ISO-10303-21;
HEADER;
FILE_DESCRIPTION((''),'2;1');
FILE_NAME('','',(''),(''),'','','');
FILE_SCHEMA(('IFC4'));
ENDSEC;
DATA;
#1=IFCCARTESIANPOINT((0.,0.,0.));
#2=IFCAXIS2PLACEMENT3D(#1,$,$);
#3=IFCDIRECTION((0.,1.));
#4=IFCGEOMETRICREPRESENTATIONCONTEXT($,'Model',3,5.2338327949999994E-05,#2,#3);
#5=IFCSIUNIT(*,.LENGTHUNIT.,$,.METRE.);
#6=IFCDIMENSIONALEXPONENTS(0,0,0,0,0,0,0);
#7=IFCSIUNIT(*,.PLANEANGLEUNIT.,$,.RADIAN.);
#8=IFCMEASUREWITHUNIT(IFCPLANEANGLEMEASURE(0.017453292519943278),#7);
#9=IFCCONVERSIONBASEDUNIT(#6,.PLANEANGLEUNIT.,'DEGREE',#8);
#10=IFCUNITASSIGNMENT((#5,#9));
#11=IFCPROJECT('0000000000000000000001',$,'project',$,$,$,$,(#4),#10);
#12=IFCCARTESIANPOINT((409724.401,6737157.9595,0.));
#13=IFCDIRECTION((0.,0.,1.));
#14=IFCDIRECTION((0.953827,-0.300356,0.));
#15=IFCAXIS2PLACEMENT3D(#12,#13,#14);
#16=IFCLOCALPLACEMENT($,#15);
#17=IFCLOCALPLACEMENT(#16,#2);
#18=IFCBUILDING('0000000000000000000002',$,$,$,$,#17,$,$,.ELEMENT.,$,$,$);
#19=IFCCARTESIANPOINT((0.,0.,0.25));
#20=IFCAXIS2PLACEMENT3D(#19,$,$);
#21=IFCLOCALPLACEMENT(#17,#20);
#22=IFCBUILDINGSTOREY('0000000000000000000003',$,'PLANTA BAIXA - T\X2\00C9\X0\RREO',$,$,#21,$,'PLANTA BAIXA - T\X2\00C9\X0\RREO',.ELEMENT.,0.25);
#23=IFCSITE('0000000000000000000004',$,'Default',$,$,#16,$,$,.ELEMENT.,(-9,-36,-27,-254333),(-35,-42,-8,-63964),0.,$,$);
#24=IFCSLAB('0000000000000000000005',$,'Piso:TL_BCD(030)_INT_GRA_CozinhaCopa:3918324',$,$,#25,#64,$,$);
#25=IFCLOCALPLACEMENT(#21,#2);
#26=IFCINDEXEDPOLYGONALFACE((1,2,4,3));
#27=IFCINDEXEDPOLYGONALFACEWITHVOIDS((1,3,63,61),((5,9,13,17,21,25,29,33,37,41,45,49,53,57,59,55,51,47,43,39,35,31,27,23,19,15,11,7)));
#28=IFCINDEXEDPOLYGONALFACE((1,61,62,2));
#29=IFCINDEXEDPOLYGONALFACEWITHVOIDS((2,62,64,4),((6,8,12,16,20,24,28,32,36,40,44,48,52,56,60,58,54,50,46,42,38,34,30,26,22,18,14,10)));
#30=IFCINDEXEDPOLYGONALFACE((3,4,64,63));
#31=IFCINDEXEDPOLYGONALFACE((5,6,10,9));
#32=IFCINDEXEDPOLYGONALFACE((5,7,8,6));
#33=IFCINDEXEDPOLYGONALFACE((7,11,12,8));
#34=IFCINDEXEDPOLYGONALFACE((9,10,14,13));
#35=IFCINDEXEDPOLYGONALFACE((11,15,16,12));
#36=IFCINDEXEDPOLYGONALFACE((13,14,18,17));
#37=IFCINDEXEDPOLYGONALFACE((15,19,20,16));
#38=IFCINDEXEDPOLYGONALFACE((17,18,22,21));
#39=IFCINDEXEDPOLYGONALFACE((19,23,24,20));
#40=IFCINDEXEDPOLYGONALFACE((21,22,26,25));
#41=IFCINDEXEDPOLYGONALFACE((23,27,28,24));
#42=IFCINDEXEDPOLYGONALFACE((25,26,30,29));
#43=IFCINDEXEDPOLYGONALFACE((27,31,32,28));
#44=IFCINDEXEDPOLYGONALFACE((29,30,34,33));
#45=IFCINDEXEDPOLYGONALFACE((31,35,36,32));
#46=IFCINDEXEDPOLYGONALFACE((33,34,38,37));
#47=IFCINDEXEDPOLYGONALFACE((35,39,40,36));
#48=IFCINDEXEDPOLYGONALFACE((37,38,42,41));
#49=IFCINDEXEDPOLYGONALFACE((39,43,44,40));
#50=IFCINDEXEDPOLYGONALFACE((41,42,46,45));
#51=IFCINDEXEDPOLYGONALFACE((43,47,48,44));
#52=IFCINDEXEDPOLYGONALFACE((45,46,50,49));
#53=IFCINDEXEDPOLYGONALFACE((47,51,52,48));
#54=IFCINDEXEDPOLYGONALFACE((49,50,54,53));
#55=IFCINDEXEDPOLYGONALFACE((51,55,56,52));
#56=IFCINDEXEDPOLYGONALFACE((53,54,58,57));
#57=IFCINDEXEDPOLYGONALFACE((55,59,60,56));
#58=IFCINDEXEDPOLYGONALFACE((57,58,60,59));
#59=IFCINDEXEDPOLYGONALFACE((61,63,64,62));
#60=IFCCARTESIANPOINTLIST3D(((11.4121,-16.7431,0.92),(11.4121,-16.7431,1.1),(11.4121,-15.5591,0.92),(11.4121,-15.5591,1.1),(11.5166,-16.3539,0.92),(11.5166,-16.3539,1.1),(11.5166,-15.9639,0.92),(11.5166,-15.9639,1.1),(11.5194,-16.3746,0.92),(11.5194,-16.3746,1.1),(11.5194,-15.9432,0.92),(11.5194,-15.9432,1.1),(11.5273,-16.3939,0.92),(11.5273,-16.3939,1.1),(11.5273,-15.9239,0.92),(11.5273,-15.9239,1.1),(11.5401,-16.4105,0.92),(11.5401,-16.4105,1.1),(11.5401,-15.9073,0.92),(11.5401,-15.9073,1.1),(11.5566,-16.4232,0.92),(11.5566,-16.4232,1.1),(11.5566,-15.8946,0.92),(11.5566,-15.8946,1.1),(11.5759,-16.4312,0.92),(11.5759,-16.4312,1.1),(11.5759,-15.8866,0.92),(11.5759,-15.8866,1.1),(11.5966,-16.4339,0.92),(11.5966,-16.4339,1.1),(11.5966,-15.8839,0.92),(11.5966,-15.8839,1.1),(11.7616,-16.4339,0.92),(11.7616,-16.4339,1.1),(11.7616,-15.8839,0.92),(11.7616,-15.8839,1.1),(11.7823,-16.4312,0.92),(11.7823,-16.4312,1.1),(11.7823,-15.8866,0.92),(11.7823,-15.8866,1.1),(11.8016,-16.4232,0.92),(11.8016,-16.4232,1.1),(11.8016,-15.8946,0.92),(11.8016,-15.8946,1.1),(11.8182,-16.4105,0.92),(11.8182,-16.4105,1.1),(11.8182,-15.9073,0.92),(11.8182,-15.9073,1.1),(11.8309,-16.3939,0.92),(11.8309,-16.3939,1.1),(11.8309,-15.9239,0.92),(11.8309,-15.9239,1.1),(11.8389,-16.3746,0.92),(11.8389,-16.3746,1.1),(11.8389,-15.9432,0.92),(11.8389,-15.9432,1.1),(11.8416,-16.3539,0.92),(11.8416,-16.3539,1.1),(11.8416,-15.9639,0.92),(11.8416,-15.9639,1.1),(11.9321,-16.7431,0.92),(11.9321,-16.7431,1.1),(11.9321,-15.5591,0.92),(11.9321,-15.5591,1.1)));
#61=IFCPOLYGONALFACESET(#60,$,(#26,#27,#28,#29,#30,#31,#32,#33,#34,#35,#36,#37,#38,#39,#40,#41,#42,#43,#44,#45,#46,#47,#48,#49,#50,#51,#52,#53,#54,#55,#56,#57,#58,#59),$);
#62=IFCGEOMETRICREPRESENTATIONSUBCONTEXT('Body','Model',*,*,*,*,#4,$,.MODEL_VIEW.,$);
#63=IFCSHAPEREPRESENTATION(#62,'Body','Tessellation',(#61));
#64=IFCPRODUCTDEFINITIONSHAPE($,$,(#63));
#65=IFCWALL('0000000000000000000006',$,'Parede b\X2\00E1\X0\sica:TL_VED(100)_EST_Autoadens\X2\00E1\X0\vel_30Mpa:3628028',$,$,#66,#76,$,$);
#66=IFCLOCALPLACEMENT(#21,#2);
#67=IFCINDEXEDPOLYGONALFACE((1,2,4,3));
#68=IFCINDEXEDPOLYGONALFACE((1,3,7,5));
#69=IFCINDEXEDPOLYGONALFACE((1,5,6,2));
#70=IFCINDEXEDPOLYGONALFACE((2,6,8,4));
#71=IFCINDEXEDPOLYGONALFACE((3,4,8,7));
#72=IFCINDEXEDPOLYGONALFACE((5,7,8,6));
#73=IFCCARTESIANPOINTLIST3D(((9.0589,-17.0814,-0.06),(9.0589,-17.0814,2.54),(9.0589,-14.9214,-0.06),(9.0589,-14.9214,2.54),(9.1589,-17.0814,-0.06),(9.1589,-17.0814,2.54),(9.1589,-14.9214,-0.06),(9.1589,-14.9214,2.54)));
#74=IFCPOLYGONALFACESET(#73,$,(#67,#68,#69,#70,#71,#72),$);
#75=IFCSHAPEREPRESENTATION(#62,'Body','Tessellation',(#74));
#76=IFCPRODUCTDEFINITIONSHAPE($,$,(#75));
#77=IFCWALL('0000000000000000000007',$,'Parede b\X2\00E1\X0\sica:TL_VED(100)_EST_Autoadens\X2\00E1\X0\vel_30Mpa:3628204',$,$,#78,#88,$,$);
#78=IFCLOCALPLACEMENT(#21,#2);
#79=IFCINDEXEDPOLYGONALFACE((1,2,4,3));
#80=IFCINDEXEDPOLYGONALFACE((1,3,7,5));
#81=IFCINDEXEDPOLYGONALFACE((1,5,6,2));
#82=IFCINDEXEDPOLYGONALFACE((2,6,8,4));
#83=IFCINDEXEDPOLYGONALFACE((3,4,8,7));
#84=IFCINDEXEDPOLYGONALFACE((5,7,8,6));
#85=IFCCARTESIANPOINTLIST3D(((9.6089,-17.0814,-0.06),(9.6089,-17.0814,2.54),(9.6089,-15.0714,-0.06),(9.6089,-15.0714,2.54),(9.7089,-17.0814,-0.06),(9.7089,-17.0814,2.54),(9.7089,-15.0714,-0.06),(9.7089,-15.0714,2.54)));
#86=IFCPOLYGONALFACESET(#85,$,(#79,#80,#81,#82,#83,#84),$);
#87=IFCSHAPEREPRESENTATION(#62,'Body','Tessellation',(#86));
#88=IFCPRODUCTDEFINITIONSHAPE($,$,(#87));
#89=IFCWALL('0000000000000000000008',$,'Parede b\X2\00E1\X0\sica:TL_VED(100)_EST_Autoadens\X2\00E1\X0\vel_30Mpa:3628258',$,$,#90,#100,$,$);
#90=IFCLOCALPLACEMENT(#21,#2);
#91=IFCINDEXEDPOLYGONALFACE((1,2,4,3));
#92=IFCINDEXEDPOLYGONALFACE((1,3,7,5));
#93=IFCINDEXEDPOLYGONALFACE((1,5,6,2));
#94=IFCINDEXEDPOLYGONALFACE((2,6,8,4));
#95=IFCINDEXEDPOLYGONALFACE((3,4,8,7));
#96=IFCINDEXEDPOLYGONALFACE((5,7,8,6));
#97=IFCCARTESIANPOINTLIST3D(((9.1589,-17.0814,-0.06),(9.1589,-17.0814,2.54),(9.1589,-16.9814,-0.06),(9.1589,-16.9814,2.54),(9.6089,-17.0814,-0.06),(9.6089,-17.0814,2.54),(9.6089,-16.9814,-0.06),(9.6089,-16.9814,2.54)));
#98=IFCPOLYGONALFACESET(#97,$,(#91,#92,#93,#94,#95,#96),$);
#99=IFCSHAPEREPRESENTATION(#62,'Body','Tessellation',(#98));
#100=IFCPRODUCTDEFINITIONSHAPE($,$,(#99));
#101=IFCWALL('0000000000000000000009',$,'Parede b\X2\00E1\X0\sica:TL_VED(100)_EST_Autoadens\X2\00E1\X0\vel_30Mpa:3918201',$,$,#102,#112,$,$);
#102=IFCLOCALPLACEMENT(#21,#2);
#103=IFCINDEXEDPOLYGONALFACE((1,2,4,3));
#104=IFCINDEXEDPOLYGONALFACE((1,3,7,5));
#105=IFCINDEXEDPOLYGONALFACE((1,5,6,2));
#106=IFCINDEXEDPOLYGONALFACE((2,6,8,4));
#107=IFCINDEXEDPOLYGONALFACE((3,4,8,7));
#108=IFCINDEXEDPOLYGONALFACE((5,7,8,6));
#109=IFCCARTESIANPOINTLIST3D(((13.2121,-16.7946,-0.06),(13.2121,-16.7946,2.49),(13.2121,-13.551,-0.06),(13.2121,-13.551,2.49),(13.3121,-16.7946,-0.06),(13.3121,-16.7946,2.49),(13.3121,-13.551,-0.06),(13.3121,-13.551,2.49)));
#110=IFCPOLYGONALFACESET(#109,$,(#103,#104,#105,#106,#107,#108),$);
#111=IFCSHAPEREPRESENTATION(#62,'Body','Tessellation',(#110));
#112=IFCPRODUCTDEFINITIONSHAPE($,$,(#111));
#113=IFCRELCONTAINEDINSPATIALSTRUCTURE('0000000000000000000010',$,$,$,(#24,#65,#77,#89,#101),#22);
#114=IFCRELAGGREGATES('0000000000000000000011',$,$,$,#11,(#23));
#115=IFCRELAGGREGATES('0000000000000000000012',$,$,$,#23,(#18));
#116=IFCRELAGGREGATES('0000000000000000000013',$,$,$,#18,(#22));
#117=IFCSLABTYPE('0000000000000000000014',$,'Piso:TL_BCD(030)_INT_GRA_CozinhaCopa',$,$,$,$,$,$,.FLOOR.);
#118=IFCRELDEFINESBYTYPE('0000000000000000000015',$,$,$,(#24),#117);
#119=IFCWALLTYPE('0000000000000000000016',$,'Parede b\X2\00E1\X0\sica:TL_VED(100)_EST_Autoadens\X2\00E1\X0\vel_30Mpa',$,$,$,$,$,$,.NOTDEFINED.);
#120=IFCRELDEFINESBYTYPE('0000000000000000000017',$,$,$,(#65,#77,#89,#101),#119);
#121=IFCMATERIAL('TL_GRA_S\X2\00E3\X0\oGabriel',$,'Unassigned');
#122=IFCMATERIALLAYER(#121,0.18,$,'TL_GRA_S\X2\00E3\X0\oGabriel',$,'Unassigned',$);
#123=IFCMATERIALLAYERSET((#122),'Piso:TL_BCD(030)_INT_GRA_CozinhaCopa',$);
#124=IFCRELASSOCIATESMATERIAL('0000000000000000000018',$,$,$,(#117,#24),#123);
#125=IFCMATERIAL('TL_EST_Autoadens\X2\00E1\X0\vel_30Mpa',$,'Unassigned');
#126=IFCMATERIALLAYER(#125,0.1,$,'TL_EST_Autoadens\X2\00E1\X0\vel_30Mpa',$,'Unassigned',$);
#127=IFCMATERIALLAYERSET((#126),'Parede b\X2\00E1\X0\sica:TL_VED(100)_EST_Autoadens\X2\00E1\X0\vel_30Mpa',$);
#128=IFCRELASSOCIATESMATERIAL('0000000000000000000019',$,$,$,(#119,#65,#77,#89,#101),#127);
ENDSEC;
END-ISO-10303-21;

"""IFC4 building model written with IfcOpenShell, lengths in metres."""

from ifc_helpers import new_model, entity, si_unit, converted_unit, direction, frame, frame_2d, origin, place, context, subcontext, project, spatial, polyline, circle_curve, parameter, trimmed, segment, composite_curve, rectangle, outline, extrude, material, layer, layer_set, layer_usage, type_object, element, save


model = new_model("IFC4")

# Units and contexts
model_context = context("Model", 3, precision=5.2338327949999994e-05, world=origin(), true_north=direction((0.0, 1.0)))
body_context = subcontext(model_context, "Body", "Model", "MODEL_VIEW")
ifc_project = project(units=[si_unit("LENGTHUNIT", "METRE"), converted_unit("PLANEANGLEUNIT", "DEGREE", entity("IfcPlaneAngleMeasure", 0.017453292519943278), si_unit("PLANEANGLEUNIT", "RADIAN"), dimensions=[0, 0, 0, 0, 0, 0, 0])], contexts=[model_context])

# Site, building, storey
site_placement = place(None, frame((409724.401, 6737157.9595, 0.0), z_axis=(0.0, 0.0, 1.0), x_axis=(0.953827, -0.300356, 0.0)))
site = spatial("IfcSite", under=ifc_project, at=site_placement, Name="Default", CompositionType="ELEMENT", RefLatitude=(-9, -36, -27, -254333), RefLongitude=(-35, -42, -8, -63964), RefElevation=0.0)
building_placement = place(site_placement, origin())
building = spatial("IfcBuilding", under=site, at=building_placement, CompositionType="ELEMENT")
storey_placement = place(building_placement, frame((0.0, 0.0, 0.25)))
storey = spatial("IfcBuildingStorey", under=building, at=storey_placement, Name="PLANTA BAIXA - TÉRREO", LongName="PLANTA BAIXA - TÉRREO", CompositionType="ELEMENT", Elevation=0.25)

# Slab, opening
ifc_material_1 = material(Name="TL_GRA_SãoGabriel", Category="Unassigned")
ifc_layer_1 = layer(ifc_material_1, 0.18, Name="TL_GRA_SãoGabriel", Category="Unassigned")
ifc_layer_set_1 = layer_set([ifc_layer_1], Name="Piso:TL_BCD(030)_INT_GRA_CozinhaCopa")
ifc_layer_usage_1 = layer_usage(ifc_layer_set_1, "AXIS3", "POSITIVE", 0.0)
slab_type = type_object("IfcSlabType", Name="Piso:TL_BCD(030)_INT_GRA_CozinhaCopa", PredefinedType="FLOOR", material=ifc_layer_set_1)
slab_placement = place(storey_placement, frame((11.4121, -16.7431, 0.92)))
slab = element("IfcSlab", 1, at=slab_placement, inside=storey, type_object=slab_type, material=ifc_layer_usage_1, Name="Piso:TL_BCD(030)_INT_GRA_CozinhaCopa:3918324", context=body_context, shape_type="SweptSolid", body=[
    extrude(rectangle(XDim=0.52, YDim=1.184, at=frame_2d((0.0, 0.0), x_axis=(-1.0, 0.0))), frame((0.26, 0.592, 0.18), z_axis=(0.0, 0.0, -1.0), x_axis=(-1.0, 0.0, 0.0)), (0.0, 0.0, 1.0), 0.18),
])
opening_1_placement = place(slab_placement, frame((-11.4121, 16.7431, 0.18)))
element("IfcOpeningElement", 2, at=opening_1_placement, cuts=slab, PredefinedType="OPENING", context=body_context, shape_type="SweptSolid", body=[
    extrude(outline(composite_curve([segment(trimmed(circle_curve(frame_2d((0.195, -0.0825), x_axis=(1.0, 0.0)), 0.08), [parameter(270.0)], [parameter(0.0)], True, "PARAMETER"), True, "CONTINUOUS"), segment(polyline([(0.275, -0.0825), (0.275, 0.0825)]), True, "CONTINUOUS"), segment(trimmed(circle_curve(frame_2d((0.195, 0.0825), x_axis=(1.0, 0.0)), 0.08), [parameter(0.0)], [parameter(90.0)], True, "PARAMETER"), True, "CONTINUOUS"), segment(polyline([(0.195, 0.1625), (-0.195, 0.1625)]), True, "CONTINUOUS"), segment(trimmed(circle_curve(frame_2d((-0.195, 0.0825), x_axis=(1.0, 0.0)), 0.08), [parameter(90.0)], [parameter(180.0)], True, "PARAMETER"), True, "CONTINUOUS"), segment(polyline([(-0.275, 0.0825), (-0.275, -0.0825)]), True, "CONTINUOUS"), segment(trimmed(circle_curve(frame_2d((-0.195, -0.0825), x_axis=(1.0, 0.0)), 0.08), [parameter(180.0)], [parameter(270.0)], True, "PARAMETER"), True, "CONTINUOUS"), segment(polyline([(-0.195, -0.1625), (0.195, -0.1625)]), True, "CONTINUOUS")], self_intersect=False)), frame((11.6791, -16.1589, -0.21), z_axis=(0.0, 0.0, 1.0), x_axis=(0.0, -1.0, 0.0)), (0.0, 0.0, 1.0), 0.21),
])

# Walls
ifc_material_2 = material(Name="TL_EST_Autoadensável_30Mpa", Category="Unassigned")
ifc_layer_2 = layer(ifc_material_2, 0.1, Name="TL_EST_Autoadensável_30Mpa", Category="Unassigned")
ifc_layer_set_2 = layer_set([ifc_layer_2], Name="Parede básica:TL_VED(100)_EST_Autoadensável_30Mpa")
ifc_layer_usage_2 = layer_usage(ifc_layer_set_2, "AXIS2", "NEGATIVE", 0.05)
wall_type_1 = type_object("IfcWallType", Name="Parede básica:TL_VED(100)_EST_Autoadensável_30Mpa", PredefinedType="NOTDEFINED", material=ifc_layer_set_2)
wall_1_placement = place(storey_placement, frame((9.1089, -17.0814, -0.06), z_axis=(0.0, 0.0, 1.0), x_axis=(0.0, 1.0, 0.0)))
element("IfcWall", 3, at=wall_1_placement, inside=storey, type_object=wall_type_1, material=ifc_layer_usage_2, Name="Parede básica:TL_VED(100)_EST_Autoadensável_30Mpa:3628028", context=body_context, shape_type="SweptSolid", body=[
    extrude(rectangle(XDim=2.16, YDim=0.1, at=frame_2d((1.08, 0.0), x_axis=(-1.0, 0.0))), origin(), (0.0, 0.0, 1.0), 2.6),
])
ifc_layer_usage_3 = layer_usage(ifc_layer_set_2, "AXIS2", "NEGATIVE", 0.05)
wall_2_placement = place(storey_placement, frame((9.6589, -15.0714, -0.06), z_axis=(0.0, 0.0, 1.0), x_axis=(0.0, -1.0, 0.0)))
element("IfcWall", 4, at=wall_2_placement, inside=storey, type_object=wall_type_1, material=ifc_layer_usage_3, Name="Parede básica:TL_VED(100)_EST_Autoadensável_30Mpa:3628204", context=body_context, shape_type="SweptSolid", body=[
    extrude(rectangle(XDim=2.01, YDim=0.1, at=frame_2d((1.005, 0.0), x_axis=(-1.0, 0.0))), origin(), (0.0, 0.0, 1.0), 2.6),
])
ifc_layer_usage_4 = layer_usage(ifc_layer_set_2, "AXIS2", "NEGATIVE", 0.05)
wall_3_placement = place(storey_placement, frame((9.6089, -17.0314, -0.06), z_axis=(0.0, 0.0, 1.0), x_axis=(-1.0, 0.0, 0.0)))
element("IfcWall", 5, at=wall_3_placement, inside=storey, type_object=wall_type_1, material=ifc_layer_usage_4, Name="Parede básica:TL_VED(100)_EST_Autoadensável_30Mpa:3628258", context=body_context, shape_type="SweptSolid", body=[
    extrude(rectangle(XDim=0.45, YDim=0.1, at=frame_2d((0.225, 0.0), x_axis=(-1.0, 0.0))), origin(), (0.0, 0.0, 1.0), 2.6),
])
ifc_layer_usage_5 = layer_usage(ifc_layer_set_2, "AXIS2", "POSITIVE", -0.05)
wall_4_placement = place(storey_placement, frame((13.2621, -13.551, -0.06), z_axis=(0.0, 0.0, 1.0), x_axis=(0.0, -1.0, 0.0)))
element("IfcWall", 6, at=wall_4_placement, inside=storey, type_object=wall_type_1, material=ifc_layer_usage_5, Name="Parede básica:TL_VED(100)_EST_Autoadensável_30Mpa:3918201", context=body_context, shape_type="SweptSolid", body=[
    extrude(rectangle(XDim=3.2437, YDim=0.1, at=frame_2d((1.6218, 0.0), x_axis=(-1.0, 0.0))), origin(), (0.0, 0.0, 1.0), 2.55),
])

save(model, "model.ifc")
